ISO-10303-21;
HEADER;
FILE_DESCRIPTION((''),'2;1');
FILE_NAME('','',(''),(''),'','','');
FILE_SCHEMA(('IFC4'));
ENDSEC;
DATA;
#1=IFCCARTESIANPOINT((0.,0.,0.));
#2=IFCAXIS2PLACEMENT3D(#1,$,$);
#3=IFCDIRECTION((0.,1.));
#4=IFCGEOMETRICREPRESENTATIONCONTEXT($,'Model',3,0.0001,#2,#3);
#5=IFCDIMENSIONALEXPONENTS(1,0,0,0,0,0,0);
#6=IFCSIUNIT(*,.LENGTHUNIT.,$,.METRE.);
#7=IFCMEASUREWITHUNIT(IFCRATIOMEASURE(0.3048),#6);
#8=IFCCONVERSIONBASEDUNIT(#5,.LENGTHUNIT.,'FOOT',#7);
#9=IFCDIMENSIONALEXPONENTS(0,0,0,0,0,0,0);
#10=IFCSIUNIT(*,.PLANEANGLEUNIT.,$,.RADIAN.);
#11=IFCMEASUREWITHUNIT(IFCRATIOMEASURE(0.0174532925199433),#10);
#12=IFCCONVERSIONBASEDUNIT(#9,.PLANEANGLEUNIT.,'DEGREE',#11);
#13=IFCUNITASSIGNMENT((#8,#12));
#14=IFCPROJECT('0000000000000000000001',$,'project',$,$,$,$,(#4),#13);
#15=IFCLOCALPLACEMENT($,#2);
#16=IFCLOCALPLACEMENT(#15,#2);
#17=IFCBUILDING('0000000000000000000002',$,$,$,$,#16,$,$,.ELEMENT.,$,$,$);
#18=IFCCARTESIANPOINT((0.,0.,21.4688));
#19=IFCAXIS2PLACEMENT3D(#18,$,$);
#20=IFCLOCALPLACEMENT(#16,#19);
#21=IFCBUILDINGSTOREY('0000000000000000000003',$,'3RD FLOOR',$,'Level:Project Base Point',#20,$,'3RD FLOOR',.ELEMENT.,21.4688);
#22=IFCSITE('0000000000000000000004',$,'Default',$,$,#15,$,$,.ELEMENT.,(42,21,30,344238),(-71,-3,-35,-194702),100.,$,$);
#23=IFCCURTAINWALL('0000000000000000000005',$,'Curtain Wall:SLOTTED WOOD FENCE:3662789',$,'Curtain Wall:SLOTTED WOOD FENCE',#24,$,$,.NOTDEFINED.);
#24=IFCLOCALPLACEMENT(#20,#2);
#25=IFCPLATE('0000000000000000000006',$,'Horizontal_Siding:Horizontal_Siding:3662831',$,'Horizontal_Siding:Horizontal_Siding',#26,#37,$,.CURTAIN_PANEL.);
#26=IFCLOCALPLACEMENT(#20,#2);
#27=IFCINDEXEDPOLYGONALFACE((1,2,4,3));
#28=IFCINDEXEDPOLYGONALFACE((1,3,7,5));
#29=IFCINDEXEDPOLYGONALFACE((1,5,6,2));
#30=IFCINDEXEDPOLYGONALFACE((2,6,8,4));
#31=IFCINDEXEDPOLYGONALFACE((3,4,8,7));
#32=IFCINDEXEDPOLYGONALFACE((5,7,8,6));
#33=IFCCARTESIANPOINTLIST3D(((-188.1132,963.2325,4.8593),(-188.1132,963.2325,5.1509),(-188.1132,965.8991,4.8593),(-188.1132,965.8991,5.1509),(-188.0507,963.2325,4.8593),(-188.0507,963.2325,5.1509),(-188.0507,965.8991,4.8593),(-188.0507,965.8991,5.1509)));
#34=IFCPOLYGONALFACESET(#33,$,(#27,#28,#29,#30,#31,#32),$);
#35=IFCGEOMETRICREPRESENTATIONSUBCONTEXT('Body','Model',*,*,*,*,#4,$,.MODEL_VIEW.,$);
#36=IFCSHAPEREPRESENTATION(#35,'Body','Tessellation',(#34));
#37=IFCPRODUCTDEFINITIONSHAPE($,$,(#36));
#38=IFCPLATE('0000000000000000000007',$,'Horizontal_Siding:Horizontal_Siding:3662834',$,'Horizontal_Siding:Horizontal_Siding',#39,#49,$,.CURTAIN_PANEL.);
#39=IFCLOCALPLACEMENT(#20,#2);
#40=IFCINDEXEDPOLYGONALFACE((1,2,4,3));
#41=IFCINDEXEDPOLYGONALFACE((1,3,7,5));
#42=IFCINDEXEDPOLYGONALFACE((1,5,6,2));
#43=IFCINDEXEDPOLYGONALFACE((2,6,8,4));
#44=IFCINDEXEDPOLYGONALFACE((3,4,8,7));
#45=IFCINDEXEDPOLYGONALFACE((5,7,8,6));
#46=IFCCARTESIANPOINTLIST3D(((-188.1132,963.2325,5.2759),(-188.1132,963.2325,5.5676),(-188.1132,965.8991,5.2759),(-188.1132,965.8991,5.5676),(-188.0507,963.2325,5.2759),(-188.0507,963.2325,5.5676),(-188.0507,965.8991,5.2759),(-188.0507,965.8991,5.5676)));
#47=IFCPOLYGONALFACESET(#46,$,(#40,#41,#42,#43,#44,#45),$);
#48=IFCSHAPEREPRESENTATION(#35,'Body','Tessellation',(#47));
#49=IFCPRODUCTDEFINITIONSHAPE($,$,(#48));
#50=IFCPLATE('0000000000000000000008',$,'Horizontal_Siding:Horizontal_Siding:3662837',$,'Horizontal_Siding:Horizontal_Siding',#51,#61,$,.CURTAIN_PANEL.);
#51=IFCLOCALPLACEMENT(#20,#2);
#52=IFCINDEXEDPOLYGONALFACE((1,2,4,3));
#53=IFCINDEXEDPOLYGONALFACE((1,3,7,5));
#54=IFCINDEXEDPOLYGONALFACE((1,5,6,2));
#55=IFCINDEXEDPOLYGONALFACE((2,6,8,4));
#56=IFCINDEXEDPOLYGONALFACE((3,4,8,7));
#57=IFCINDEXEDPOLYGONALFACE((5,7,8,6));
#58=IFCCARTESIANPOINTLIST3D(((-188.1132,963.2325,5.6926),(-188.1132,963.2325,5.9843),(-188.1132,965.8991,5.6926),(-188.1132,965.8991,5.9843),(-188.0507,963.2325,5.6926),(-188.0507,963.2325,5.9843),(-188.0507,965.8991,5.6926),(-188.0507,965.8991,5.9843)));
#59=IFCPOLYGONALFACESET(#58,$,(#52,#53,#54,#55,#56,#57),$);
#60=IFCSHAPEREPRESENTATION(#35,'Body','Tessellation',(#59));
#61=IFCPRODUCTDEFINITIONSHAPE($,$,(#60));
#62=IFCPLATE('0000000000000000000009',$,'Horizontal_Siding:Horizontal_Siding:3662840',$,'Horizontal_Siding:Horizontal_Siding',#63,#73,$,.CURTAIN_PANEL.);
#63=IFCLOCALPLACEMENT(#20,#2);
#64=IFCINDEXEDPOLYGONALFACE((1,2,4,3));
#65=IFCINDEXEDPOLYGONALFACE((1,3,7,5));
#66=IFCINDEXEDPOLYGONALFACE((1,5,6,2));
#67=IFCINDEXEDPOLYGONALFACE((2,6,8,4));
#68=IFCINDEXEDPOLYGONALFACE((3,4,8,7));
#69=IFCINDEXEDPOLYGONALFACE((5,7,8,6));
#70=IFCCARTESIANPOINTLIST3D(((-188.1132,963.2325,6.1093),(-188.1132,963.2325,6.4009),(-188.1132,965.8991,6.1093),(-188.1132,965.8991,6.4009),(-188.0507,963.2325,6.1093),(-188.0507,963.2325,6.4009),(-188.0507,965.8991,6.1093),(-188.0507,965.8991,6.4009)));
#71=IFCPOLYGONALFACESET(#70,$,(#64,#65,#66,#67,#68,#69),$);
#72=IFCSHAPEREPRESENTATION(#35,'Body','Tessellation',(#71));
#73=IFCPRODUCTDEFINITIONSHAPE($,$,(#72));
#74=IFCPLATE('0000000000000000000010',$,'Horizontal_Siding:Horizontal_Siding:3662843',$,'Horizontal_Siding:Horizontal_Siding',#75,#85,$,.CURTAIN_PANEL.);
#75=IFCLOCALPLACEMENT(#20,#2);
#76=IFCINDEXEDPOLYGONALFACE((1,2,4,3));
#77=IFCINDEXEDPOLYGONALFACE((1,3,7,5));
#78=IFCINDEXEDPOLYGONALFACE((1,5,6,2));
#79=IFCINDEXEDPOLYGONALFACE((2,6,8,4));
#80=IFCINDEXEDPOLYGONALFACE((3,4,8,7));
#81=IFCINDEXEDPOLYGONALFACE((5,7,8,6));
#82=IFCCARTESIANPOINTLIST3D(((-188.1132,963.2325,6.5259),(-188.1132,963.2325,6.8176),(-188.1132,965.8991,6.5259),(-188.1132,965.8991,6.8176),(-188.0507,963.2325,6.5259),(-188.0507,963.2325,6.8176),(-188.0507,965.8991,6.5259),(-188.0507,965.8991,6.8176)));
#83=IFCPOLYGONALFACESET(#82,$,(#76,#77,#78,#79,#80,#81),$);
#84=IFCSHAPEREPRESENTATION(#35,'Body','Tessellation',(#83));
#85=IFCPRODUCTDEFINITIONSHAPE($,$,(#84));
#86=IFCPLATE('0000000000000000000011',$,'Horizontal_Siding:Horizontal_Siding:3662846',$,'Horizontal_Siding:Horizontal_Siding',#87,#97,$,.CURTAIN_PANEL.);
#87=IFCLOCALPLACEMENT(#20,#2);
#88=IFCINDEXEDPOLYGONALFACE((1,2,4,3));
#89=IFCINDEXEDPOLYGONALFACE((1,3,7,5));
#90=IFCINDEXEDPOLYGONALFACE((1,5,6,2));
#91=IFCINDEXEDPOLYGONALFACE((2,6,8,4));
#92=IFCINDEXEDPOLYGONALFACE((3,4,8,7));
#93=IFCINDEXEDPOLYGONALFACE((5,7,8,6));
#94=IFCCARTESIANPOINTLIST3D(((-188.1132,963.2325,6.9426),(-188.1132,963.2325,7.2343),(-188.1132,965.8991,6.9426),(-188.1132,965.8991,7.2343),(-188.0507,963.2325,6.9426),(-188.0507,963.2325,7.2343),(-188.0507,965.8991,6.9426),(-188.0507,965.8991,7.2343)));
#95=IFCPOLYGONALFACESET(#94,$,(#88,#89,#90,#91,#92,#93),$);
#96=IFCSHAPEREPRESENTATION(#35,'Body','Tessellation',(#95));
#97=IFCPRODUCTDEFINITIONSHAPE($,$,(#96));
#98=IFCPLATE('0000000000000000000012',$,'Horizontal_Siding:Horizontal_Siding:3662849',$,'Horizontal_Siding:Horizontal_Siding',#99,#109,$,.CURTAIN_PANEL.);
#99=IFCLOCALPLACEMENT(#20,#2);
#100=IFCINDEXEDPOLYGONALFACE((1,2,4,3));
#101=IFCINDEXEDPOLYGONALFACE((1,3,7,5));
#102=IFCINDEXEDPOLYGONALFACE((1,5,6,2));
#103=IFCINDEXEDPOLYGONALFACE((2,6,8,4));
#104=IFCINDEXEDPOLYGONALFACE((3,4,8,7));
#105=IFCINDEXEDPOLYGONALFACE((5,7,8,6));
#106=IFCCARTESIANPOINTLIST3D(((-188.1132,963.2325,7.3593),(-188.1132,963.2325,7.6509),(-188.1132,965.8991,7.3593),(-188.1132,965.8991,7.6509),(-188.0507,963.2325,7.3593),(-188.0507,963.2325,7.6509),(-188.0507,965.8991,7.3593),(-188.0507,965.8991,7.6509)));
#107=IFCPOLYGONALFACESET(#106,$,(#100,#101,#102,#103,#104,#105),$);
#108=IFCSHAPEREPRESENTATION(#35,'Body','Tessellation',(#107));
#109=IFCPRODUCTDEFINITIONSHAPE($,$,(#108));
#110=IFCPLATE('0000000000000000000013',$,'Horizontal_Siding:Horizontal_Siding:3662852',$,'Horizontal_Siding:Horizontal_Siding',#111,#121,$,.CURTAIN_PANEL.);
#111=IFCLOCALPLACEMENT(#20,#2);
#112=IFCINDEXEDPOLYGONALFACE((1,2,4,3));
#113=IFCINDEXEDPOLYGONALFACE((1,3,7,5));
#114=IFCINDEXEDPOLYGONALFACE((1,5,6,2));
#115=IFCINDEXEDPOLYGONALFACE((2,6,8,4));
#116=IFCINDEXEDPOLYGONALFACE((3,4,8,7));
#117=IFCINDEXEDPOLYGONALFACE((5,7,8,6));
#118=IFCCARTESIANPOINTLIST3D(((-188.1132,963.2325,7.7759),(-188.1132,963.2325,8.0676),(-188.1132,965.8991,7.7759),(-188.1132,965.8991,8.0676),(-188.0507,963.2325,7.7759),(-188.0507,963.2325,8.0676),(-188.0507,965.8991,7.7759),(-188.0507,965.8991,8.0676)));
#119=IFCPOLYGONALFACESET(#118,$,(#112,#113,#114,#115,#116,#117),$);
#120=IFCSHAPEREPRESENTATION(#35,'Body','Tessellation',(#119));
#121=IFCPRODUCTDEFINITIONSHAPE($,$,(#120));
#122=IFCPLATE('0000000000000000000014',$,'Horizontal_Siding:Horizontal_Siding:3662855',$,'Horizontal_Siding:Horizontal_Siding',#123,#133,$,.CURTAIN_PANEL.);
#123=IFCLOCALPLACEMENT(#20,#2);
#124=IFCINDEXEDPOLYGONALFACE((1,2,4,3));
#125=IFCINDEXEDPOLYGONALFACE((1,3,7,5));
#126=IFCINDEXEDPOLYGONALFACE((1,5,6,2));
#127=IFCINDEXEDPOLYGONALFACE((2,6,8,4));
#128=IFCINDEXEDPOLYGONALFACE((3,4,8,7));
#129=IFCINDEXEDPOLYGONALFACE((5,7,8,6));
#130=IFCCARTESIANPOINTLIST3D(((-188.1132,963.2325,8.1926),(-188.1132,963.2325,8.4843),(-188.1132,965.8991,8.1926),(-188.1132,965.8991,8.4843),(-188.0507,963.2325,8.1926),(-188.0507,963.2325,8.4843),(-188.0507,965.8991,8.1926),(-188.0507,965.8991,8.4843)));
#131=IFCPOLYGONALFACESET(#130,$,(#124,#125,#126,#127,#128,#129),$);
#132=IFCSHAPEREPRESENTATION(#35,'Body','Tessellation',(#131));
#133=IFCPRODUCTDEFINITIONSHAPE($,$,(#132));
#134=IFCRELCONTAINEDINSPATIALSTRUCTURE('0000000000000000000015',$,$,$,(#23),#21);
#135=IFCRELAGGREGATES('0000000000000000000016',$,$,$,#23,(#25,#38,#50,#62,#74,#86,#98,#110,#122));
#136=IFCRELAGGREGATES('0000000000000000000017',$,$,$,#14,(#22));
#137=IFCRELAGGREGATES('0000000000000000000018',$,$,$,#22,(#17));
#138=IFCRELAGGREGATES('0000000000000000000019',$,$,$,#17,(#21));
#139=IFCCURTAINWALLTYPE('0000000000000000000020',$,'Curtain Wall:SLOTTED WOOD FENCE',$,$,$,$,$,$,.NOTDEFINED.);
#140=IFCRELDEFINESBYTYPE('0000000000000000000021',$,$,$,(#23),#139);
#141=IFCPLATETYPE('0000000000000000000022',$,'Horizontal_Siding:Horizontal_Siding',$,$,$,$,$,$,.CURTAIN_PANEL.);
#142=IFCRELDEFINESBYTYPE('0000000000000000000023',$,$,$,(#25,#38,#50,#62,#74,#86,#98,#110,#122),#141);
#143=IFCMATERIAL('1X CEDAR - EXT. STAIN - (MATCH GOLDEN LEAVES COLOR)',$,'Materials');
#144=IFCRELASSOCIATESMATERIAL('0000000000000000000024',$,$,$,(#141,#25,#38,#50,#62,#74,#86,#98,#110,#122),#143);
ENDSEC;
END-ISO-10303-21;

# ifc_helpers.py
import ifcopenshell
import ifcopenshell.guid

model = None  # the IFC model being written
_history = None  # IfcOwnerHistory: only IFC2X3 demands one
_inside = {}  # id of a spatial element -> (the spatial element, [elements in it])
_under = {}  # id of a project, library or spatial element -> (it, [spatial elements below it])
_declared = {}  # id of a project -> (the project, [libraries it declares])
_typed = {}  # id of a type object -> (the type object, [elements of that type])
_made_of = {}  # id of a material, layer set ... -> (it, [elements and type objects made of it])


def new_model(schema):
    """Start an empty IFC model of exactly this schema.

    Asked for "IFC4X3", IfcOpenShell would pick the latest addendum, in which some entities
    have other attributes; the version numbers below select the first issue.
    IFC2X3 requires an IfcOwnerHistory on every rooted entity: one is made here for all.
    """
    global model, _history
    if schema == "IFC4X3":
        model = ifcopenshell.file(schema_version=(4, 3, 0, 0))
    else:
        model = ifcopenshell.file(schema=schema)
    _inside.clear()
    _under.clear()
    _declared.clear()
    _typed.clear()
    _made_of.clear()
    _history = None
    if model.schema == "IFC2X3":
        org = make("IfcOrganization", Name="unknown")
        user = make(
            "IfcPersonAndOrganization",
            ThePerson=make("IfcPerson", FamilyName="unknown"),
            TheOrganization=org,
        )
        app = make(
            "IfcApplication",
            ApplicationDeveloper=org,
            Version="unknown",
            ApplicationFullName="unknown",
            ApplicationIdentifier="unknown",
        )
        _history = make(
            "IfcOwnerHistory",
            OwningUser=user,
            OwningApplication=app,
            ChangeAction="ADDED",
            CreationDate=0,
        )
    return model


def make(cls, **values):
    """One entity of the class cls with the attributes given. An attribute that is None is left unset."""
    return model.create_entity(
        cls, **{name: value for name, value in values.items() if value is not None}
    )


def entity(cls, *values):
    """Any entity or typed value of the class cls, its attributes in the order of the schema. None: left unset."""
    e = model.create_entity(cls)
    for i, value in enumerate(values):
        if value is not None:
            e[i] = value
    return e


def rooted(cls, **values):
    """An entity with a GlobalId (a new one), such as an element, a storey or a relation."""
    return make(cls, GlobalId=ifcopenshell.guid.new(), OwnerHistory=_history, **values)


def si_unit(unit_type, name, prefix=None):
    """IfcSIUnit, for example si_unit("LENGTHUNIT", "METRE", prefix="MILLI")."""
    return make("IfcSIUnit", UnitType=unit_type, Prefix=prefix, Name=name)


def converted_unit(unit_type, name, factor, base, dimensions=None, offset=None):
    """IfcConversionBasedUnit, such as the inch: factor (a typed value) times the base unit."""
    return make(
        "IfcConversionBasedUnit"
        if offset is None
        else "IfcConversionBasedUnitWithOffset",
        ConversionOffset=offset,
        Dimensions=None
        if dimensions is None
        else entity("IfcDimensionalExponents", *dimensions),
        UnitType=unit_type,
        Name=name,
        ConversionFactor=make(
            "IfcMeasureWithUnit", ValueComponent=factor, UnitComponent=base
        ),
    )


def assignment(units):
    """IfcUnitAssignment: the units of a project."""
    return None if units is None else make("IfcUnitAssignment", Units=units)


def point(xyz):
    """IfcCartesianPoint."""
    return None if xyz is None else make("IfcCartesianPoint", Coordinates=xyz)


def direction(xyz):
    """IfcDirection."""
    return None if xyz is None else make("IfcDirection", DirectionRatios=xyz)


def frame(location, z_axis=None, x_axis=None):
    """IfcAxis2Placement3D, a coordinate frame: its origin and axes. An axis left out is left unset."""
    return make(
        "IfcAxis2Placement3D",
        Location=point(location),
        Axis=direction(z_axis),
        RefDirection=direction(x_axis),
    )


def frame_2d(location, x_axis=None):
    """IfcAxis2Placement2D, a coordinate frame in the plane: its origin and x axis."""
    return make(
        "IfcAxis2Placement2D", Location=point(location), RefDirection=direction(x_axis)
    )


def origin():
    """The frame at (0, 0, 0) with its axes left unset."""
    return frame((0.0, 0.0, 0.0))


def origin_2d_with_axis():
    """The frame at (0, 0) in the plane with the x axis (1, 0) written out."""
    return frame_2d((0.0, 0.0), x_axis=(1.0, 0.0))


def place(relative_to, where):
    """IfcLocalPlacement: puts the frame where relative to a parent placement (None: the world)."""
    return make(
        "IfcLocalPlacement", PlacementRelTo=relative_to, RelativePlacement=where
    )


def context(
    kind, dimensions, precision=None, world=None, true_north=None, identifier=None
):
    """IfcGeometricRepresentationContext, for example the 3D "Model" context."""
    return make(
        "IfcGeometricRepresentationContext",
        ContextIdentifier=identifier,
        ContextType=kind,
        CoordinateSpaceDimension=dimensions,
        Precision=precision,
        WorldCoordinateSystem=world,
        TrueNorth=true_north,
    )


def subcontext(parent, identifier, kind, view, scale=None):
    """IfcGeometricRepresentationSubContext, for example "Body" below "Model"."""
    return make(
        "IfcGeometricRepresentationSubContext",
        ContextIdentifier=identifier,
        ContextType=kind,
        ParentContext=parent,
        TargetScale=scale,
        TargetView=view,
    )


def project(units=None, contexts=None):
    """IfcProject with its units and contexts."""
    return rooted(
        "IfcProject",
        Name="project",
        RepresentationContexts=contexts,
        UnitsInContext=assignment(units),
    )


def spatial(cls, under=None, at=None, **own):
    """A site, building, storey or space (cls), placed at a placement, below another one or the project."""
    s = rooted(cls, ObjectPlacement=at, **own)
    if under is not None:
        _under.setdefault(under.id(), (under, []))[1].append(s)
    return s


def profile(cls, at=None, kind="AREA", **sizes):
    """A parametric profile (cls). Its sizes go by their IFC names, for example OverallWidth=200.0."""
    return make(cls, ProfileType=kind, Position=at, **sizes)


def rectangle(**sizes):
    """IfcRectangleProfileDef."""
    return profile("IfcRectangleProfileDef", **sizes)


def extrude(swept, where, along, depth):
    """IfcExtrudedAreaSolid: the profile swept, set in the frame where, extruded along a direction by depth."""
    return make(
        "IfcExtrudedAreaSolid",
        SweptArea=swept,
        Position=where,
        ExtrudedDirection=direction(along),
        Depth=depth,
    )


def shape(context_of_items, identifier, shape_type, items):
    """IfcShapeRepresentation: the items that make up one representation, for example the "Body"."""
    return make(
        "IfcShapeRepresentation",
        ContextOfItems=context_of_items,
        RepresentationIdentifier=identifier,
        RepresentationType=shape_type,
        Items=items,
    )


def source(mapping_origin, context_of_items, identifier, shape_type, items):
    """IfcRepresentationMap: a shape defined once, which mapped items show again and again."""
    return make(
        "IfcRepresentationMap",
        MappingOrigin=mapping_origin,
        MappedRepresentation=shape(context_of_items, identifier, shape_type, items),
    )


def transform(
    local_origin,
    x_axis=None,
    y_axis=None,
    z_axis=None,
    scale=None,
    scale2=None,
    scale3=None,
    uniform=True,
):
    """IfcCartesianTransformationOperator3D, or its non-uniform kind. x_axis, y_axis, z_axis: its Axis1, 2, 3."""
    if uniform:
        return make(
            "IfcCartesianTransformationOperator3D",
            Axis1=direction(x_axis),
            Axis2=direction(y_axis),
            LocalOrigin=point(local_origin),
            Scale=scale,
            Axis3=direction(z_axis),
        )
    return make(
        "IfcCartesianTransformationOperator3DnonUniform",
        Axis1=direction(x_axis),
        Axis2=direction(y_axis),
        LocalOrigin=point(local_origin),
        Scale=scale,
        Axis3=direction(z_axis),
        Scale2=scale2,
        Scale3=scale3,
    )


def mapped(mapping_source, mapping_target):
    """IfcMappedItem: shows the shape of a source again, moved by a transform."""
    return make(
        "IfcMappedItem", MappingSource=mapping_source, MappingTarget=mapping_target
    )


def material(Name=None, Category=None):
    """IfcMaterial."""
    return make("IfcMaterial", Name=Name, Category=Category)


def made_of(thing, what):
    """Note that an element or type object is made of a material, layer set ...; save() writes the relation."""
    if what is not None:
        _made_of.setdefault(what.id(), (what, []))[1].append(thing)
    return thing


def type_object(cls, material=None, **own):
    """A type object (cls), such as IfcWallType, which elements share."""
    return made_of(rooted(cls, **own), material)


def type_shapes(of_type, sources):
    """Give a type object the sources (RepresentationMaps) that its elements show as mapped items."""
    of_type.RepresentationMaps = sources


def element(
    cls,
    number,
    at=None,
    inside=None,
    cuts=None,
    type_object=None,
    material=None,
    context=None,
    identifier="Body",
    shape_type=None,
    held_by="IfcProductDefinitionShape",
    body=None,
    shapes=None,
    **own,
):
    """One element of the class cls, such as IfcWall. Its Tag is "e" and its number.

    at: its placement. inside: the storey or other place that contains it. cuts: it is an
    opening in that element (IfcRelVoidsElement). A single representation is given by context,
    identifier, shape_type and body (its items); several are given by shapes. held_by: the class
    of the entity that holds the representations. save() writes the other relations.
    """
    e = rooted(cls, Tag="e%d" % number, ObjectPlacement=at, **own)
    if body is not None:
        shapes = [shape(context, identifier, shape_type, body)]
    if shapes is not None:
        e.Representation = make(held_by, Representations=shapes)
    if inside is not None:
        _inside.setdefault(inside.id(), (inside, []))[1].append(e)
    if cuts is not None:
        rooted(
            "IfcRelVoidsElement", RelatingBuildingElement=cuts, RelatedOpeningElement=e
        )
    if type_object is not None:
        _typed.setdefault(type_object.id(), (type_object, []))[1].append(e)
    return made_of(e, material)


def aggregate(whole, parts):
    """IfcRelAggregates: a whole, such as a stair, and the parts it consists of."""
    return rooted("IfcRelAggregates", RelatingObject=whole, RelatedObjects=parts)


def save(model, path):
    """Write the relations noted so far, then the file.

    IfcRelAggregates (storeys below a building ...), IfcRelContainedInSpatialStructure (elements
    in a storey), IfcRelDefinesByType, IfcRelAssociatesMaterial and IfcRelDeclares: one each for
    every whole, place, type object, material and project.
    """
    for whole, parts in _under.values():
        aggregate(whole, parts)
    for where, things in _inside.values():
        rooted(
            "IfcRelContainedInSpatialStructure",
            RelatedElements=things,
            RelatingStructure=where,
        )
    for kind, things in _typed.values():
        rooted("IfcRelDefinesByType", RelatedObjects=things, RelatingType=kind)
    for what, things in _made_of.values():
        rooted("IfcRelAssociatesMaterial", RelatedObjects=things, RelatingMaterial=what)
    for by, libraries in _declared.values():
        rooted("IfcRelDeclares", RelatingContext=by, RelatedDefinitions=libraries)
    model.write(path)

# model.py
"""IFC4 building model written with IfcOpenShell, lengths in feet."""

from ifc_helpers import new_model, entity, si_unit, converted_unit, direction, frame, origin, origin_2d_with_axis, place, context, subcontext, project, spatial, rectangle, extrude, source, transform, mapped, material, type_object, type_shapes, element, aggregate, save


model = new_model("IFC4")

# Units and contexts
model_context = context("Model", 3, precision=0.0001, world=origin(), true_north=direction((0.0, 1.0)))
body_context = subcontext(model_context, "Body", "Model", "MODEL_VIEW")
ifc_project = project(units=[converted_unit("LENGTHUNIT", "FOOT", entity("IfcRatioMeasure", 0.3048), si_unit("LENGTHUNIT", "METRE"), dimensions=[1, 0, 0, 0, 0, 0, 0]), converted_unit("PLANEANGLEUNIT", "DEGREE", entity("IfcRatioMeasure", 0.0174532925199433), si_unit("PLANEANGLEUNIT", "RADIAN"), dimensions=[0, 0, 0, 0, 0, 0, 0])], contexts=[model_context])

# Site, building, storey
site_placement = place(None, origin())
site = spatial("IfcSite", under=ifc_project, at=site_placement, Name="Default", CompositionType="ELEMENT", RefLatitude=(42, 21, 30, 344238), RefLongitude=(-71, -3, -35, -194702), RefElevation=100.0)
building_placement = place(site_placement, origin())
building = spatial("IfcBuilding", under=site, at=building_placement, CompositionType="ELEMENT")
storey_placement = place(building_placement, frame((0.0, 0.0, 21.4688)))
storey = spatial("IfcBuildingStorey", under=building, at=storey_placement, Name="3RD FLOOR", ObjectType="Level:Project Base Point", LongName="3RD FLOOR", CompositionType="ELEMENT", Elevation=21.4688)

# Shared definitions
curtain_wall_type = type_object("IfcCurtainWallType", Name="Curtain Wall:SLOTTED WOOD FENCE", PredefinedType="NOTDEFINED")

# Curtain wall, plates
curtain_wall_1_placement = place(storey_placement, frame((0.0, 0.0, -21.4688)))
curtain_wall_1 = element("IfcCurtainWall", 1, at=curtain_wall_1_placement, inside=storey, type_object=curtain_wall_type, Name="Curtain Wall:SLOTTED WOOD FENCE:3662789", ObjectType="Curtain Wall:SLOTTED WOOD FENCE", PredefinedType="NOTDEFINED")
ifc_material_1 = material(Name="1X CEDAR - EXT. STAIN - (MATCH GOLDEN LEAVES COLOR)", Category="Materials")
plate_type = type_object("IfcPlateType", Name="Horizontal_Siding:Horizontal_Siding", PredefinedType="CURTAIN_PANEL", material=ifc_material_1)
shared_shape_1 = source(origin(), body_context, "Body", "SweptSolid", [
    extrude(rectangle(XDim=0.0625, YDim=2.6667, at=origin_2d_with_axis()), frame((1.3333, 0.0312, 0.0), z_axis=(0.0, 0.0, 1.0), x_axis=(0.0, 1.0, 0.0)), (0.0, 0.0, 1.0), 0.2917),
])
type_shapes(plate_type, [shared_shape_1])
plate_1_placement = place(curtain_wall_1_placement, frame((-188.1132, 965.8991, 26.328), z_axis=(0.0, 0.0, 1.0), x_axis=(0.0, -1.0, 0.0)))
plate_1 = element("IfcPlate", 2, at=plate_1_placement, type_object=plate_type, material=ifc_material_1, Name="Horizontal_Siding:Horizontal_Siding:3662831", ObjectType="Horizontal_Siding:Horizontal_Siding", PredefinedType="CURTAIN_PANEL", context=body_context, shape_type="MappedRepresentation", body=[
    mapped(shared_shape_1, transform((0.0, 0.0, 0.0), scale=1.0)),
])
plate_2_placement = place(curtain_wall_1_placement, frame((-188.1132, 965.8991, 26.7447), z_axis=(0.0, 0.0, 1.0), x_axis=(0.0, -1.0, 0.0)))
plate_2 = element("IfcPlate", 3, at=plate_2_placement, type_object=plate_type, material=ifc_material_1, Name="Horizontal_Siding:Horizontal_Siding:3662834", ObjectType="Horizontal_Siding:Horizontal_Siding", PredefinedType="CURTAIN_PANEL", context=body_context, shape_type="MappedRepresentation", body=[
    mapped(shared_shape_1, transform((0.0, 0.0, 0.0), scale=1.0)),
])
plate_3_placement = place(curtain_wall_1_placement, frame((-188.1132, 965.8991, 27.1613), z_axis=(0.0, 0.0, 1.0), x_axis=(0.0, -1.0, 0.0)))
plate_3 = element("IfcPlate", 4, at=plate_3_placement, type_object=plate_type, material=ifc_material_1, Name="Horizontal_Siding:Horizontal_Siding:3662837", ObjectType="Horizontal_Siding:Horizontal_Siding", PredefinedType="CURTAIN_PANEL", context=body_context, shape_type="MappedRepresentation", body=[
    mapped(shared_shape_1, transform((0.0, 0.0, 0.0), scale=1.0)),
])
plate_4_placement = place(curtain_wall_1_placement, frame((-188.1132, 965.8991, 27.578), z_axis=(0.0, 0.0, 1.0), x_axis=(0.0, -1.0, 0.0)))
plate_4 = element("IfcPlate", 5, at=plate_4_placement, type_object=plate_type, material=ifc_material_1, Name="Horizontal_Siding:Horizontal_Siding:3662840", ObjectType="Horizontal_Siding:Horizontal_Siding", PredefinedType="CURTAIN_PANEL", context=body_context, shape_type="MappedRepresentation", body=[
    mapped(shared_shape_1, transform((0.0, 0.0, 0.0), scale=1.0)),
])
plate_5_placement = place(curtain_wall_1_placement, frame((-188.1132, 965.8991, 27.9947), z_axis=(0.0, 0.0, 1.0), x_axis=(0.0, -1.0, 0.0)))
plate_5 = element("IfcPlate", 6, at=plate_5_placement, type_object=plate_type, material=ifc_material_1, Name="Horizontal_Siding:Horizontal_Siding:3662843", ObjectType="Horizontal_Siding:Horizontal_Siding", PredefinedType="CURTAIN_PANEL", context=body_context, shape_type="MappedRepresentation", body=[
    mapped(shared_shape_1, transform((0.0, 0.0, 0.0), scale=1.0)),
])
plate_6_placement = place(curtain_wall_1_placement, frame((-188.1132, 965.8991, 28.4113), z_axis=(0.0, 0.0, 1.0), x_axis=(0.0, -1.0, 0.0)))
plate_6 = element("IfcPlate", 7, at=plate_6_placement, type_object=plate_type, material=ifc_material_1, Name="Horizontal_Siding:Horizontal_Siding:3662846", ObjectType="Horizontal_Siding:Horizontal_Siding", PredefinedType="CURTAIN_PANEL", context=body_context, shape_type="MappedRepresentation", body=[
    mapped(shared_shape_1, transform((0.0, 0.0, 0.0), scale=1.0)),
])
plate_7_placement = place(curtain_wall_1_placement, frame((-188.1132, 965.8991, 28.828), z_axis=(0.0, 0.0, 1.0), x_axis=(0.0, -1.0, 0.0)))
plate_7 = element("IfcPlate", 8, at=plate_7_placement, type_object=plate_type, material=ifc_material_1, Name="Horizontal_Siding:Horizontal_Siding:3662849", ObjectType="Horizontal_Siding:Horizontal_Siding", PredefinedType="CURTAIN_PANEL", context=body_context, shape_type="MappedRepresentation", body=[
    mapped(shared_shape_1, transform((0.0, 0.0, 0.0), scale=1.0)),
])
plate_8_placement = place(curtain_wall_1_placement, frame((-188.1132, 965.8991, 29.2447), z_axis=(0.0, 0.0, 1.0), x_axis=(0.0, -1.0, 0.0)))
plate_8 = element("IfcPlate", 9, at=plate_8_placement, type_object=plate_type, material=ifc_material_1, Name="Horizontal_Siding:Horizontal_Siding:3662852", ObjectType="Horizontal_Siding:Horizontal_Siding", PredefinedType="CURTAIN_PANEL", context=body_context, shape_type="MappedRepresentation", body=[
    mapped(shared_shape_1, transform((0.0, 0.0, 0.0), scale=1.0)),
])
plate_9_placement = place(curtain_wall_1_placement, frame((-188.1132, 965.8991, 29.6613), z_axis=(0.0, 0.0, 1.0), x_axis=(0.0, -1.0, 0.0)))
plate_9 = element("IfcPlate", 10, at=plate_9_placement, type_object=plate_type, material=ifc_material_1, Name="Horizontal_Siding:Horizontal_Siding:3662855", ObjectType="Horizontal_Siding:Horizontal_Siding", PredefinedType="CURTAIN_PANEL", context=body_context, shape_type="MappedRepresentation", body=[
    mapped(shared_shape_1, transform((0.0, 0.0, 0.0), scale=1.0)),
])
aggregate(curtain_wall_1, [plate_1, plate_2, plate_3, plate_4, plate_5, plate_6, plate_7, plate_8, plate_9])

save(model, "model.ifc")
